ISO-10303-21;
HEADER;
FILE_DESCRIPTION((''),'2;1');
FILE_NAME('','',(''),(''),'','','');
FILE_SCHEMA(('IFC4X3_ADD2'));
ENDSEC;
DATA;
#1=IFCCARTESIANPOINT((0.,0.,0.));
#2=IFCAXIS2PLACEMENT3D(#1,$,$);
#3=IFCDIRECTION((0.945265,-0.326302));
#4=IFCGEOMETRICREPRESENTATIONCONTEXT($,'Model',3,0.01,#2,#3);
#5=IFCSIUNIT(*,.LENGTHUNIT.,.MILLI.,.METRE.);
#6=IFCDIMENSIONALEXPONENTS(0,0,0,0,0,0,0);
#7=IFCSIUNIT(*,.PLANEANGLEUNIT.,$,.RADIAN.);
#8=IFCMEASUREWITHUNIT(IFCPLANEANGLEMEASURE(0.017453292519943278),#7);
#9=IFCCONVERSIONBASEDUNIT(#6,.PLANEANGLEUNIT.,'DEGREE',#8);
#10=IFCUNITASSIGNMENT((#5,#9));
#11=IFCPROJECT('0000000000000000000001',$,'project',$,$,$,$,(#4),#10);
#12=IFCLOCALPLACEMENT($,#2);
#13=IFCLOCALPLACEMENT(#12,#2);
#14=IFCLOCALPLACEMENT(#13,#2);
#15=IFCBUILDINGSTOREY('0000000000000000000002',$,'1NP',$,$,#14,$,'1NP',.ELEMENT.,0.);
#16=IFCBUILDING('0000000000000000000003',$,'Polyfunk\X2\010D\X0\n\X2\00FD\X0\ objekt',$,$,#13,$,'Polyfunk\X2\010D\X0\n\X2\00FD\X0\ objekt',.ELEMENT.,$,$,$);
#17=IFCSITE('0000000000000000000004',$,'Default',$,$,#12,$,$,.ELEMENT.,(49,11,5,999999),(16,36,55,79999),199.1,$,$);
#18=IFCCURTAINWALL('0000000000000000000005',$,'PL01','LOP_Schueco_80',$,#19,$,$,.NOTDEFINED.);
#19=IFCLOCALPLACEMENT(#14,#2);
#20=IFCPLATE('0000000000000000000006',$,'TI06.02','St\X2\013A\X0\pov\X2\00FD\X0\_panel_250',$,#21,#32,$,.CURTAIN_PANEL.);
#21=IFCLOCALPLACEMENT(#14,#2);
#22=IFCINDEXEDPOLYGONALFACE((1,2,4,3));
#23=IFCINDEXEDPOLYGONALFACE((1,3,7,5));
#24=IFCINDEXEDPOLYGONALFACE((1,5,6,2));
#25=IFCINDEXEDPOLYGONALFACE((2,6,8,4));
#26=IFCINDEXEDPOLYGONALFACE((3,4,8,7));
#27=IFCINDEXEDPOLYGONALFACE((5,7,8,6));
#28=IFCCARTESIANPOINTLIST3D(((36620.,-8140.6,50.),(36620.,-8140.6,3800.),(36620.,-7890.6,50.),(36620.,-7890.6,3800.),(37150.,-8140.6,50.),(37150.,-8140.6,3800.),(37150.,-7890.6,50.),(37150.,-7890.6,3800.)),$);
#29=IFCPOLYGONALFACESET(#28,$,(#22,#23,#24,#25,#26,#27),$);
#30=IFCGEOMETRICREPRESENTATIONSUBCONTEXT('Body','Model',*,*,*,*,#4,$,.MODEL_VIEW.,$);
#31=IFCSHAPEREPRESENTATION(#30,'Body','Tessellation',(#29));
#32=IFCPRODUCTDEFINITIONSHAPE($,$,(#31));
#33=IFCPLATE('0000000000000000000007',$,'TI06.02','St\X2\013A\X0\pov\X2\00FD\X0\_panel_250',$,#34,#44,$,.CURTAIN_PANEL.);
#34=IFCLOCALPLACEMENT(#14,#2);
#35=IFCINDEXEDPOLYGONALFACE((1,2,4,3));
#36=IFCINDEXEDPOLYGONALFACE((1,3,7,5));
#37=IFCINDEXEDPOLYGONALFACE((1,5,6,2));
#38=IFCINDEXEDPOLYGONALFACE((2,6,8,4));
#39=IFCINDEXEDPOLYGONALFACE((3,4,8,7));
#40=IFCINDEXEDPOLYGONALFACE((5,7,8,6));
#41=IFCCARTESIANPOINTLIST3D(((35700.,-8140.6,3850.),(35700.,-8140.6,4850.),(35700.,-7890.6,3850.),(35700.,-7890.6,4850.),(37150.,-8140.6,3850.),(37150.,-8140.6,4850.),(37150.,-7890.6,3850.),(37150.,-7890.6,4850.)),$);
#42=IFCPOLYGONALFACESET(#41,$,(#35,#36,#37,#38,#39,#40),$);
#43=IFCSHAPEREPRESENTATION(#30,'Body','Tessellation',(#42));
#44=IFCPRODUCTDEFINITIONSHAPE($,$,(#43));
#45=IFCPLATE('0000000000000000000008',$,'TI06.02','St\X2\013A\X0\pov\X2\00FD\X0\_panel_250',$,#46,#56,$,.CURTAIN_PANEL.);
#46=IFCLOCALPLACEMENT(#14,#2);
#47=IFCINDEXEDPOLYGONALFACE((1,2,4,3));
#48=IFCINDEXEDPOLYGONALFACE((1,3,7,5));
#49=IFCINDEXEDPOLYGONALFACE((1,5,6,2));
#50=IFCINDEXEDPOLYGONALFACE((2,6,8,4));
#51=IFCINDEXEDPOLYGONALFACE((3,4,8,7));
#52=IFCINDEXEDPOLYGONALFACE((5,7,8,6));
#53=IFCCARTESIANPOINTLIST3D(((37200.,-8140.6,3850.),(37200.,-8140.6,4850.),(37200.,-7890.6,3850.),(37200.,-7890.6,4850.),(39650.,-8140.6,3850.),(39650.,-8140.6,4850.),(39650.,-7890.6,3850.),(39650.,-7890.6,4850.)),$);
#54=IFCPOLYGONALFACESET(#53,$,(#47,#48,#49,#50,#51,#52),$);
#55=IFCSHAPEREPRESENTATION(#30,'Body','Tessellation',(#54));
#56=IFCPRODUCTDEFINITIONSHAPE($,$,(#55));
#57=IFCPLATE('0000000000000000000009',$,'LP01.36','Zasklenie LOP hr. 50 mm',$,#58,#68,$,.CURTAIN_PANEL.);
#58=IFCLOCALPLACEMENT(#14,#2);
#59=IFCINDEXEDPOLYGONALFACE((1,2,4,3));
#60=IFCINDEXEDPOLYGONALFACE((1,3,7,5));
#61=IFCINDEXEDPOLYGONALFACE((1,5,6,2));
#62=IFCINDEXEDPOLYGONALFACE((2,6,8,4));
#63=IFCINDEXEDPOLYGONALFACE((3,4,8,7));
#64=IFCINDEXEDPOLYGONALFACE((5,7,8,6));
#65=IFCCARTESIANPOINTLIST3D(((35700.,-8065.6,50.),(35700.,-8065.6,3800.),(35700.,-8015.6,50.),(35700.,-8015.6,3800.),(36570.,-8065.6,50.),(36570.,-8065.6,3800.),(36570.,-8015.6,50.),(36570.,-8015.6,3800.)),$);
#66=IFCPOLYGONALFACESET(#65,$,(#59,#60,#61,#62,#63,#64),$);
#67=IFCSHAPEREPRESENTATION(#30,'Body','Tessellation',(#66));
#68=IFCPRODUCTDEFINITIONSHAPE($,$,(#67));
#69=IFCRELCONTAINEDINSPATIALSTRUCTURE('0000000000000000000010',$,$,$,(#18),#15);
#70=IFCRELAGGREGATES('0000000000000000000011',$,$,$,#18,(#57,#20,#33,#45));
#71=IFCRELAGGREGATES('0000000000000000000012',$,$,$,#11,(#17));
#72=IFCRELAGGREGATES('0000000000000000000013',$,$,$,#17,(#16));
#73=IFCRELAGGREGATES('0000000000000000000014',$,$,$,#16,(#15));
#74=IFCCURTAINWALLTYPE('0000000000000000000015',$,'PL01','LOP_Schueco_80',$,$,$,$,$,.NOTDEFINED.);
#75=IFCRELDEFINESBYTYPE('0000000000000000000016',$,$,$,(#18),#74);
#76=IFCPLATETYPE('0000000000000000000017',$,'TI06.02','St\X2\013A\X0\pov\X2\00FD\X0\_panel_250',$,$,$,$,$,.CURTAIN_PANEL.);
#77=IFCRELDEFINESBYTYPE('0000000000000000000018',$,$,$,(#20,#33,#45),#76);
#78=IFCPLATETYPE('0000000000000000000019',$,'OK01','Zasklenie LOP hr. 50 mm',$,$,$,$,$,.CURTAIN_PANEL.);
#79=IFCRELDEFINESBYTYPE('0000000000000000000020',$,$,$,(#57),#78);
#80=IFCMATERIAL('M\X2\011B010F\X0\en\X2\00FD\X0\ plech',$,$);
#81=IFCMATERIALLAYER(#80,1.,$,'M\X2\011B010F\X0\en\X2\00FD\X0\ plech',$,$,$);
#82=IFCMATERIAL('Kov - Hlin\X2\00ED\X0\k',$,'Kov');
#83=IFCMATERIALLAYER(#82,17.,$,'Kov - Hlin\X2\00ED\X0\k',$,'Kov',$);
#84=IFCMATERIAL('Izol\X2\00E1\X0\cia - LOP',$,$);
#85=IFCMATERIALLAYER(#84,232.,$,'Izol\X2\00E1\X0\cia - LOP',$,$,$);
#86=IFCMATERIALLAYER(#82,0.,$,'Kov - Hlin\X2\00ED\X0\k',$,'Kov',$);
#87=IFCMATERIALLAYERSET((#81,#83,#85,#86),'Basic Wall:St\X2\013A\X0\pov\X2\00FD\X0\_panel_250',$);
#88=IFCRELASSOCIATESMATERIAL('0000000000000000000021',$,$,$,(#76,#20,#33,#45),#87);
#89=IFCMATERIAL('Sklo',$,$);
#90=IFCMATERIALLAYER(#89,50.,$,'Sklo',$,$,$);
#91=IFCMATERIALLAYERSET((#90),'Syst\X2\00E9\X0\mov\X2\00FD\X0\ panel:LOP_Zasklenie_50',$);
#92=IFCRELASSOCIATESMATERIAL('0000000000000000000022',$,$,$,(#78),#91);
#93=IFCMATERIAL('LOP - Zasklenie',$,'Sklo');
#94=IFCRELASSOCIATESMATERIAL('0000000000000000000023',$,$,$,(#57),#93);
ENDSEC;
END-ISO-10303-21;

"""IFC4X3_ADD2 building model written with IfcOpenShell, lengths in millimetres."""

from ifc_helpers import new_model, entity, si_unit, converted_unit, direction, frame, frame_2d, origin, place, context, subcontext, project, spatial, rectangle, extrude, source, transform, mapped, material, layer, layer_set, layer_usage, type_object, type_shapes, element, aggregate, save


model = new_model("IFC4X3_ADD2")

# Units and contexts
model_context = context("Model", 3, precision=0.01, world=origin(), true_north=direction((0.945265, -0.326302)))
body_context = subcontext(model_context, "Body", "Model", "MODEL_VIEW")
ifc_project = project(units=[si_unit("LENGTHUNIT", "METRE", prefix="MILLI"), converted_unit("PLANEANGLEUNIT", "DEGREE", entity("IfcPlaneAngleMeasure", 0.017453292519943278), si_unit("PLANEANGLEUNIT", "RADIAN"), dimensions=[0, 0, 0, 0, 0, 0, 0])], contexts=[model_context])

# Site, building, storey
site_placement = place(None, origin())
site = spatial("IfcSite", under=ifc_project, at=site_placement, Name="Default", CompositionType="ELEMENT", RefLatitude=(49, 11, 5, 999999), RefLongitude=(16, 36, 55, 79999), RefElevation=199.1)
building_placement = place(site_placement, origin())
building = spatial("IfcBuilding", under=site, at=building_placement, Name="Polyfunkčný objekt", LongName="Polyfunkčný objekt", CompositionType="ELEMENT")
storey_placement = place(building_placement, origin())
storey = spatial("IfcBuildingStorey", under=building, at=storey_placement, Name="1NP", LongName="1NP", CompositionType="ELEMENT", Elevation=0.0)

# Curtain wall, plates
curtain_wall_type = type_object("IfcCurtainWallType", Name="PL01", Description="LOP_Schueco_80", PredefinedType="NOTDEFINED")
curtain_wall_placement = place(storey_placement, origin())
curtain_wall = element("IfcCurtainWall", 1, at=curtain_wall_placement, inside=storey, type_object=curtain_wall_type, Name="PL01", Description="LOP_Schueco_80", PredefinedType="NOTDEFINED")
ifc_material_1 = material(Name="Měďený plech")
ifc_layer_1 = layer(ifc_material_1, 1.0, Name="Měďený plech")
ifc_material_2 = material(Name="Kov - Hliník", Category="Kov")
ifc_layer_2 = layer(ifc_material_2, 17.0, Name="Kov - Hliník", Category="Kov")
ifc_material_3 = material(Name="Izolácia - LOP")
ifc_layer_3 = layer(ifc_material_3, 232.0, Name="Izolácia - LOP")
ifc_layer_4 = layer(ifc_material_2, 0.0, Name="Kov - Hliník", Category="Kov")
ifc_layer_set_1 = layer_set([ifc_layer_1, ifc_layer_2, ifc_layer_3, ifc_layer_4], Name="Basic Wall:Stĺpový_panel_250")
ifc_layer_usage_1 = layer_usage(ifc_layer_set_1, "AXIS2", "POSITIVE", -125.0)
plate_type_1 = type_object("IfcPlateType", Name="TI06.02", Description="Stĺpový_panel_250", PredefinedType="CURTAIN_PANEL", material=ifc_layer_set_1)
plate_1_placement = place(storey_placement, frame((36620.0, -8015.6, 50.0)))
plate_1 = element("IfcPlate", 2, at=plate_1_placement, type_object=plate_type_1, material=ifc_layer_usage_1, Name="TI06.02", Description="Stĺpový_panel_250", PredefinedType="CURTAIN_PANEL", context=body_context, shape_type="SweptSolid", body=[
    extrude(rectangle(XDim=250.0, YDim=530.0, at=frame_2d((0.0, 0.0), x_axis=(1.0, 0.0))), frame((265.0, 0.0, 0.0), z_axis=(0.0, 0.0, 1.0), x_axis=(0.0, 1.0, 0.0)), (0.0, 0.0, 1.0), 3750.0),
])
ifc_layer_usage_2 = layer_usage(ifc_layer_set_1, "AXIS2", "POSITIVE", -125.0)
plate_2_placement = place(storey_placement, frame((35700.0, -8015.6, 3850.0)))
plate_2 = element("IfcPlate", 3, at=plate_2_placement, type_object=plate_type_1, material=ifc_layer_usage_2, Name="TI06.02", Description="Stĺpový_panel_250", PredefinedType="CURTAIN_PANEL", context=body_context, shape_type="SweptSolid", body=[
    extrude(rectangle(XDim=250.0, YDim=1450.0, at=frame_2d((0.0, 0.0), x_axis=(1.0, 0.0))), frame((725.0, 0.0, 0.0), z_axis=(0.0, 0.0, 1.0), x_axis=(0.0, 1.0, 0.0)), (0.0, 0.0, 1.0), 1000.0),
])
ifc_layer_usage_3 = layer_usage(ifc_layer_set_1, "AXIS2", "POSITIVE", -125.0)
plate_3_placement = place(storey_placement, frame((37200.0, -8015.6, 3850.0)))
plate_3 = element("IfcPlate", 4, at=plate_3_placement, type_object=plate_type_1, material=ifc_layer_usage_3, Name="TI06.02", Description="Stĺpový_panel_250", PredefinedType="CURTAIN_PANEL", context=body_context, shape_type="SweptSolid", body=[
    extrude(rectangle(XDim=250.0, YDim=2450.0, at=frame_2d((0.0, 0.0), x_axis=(1.0, 0.0))), frame((1225.0, 0.0, 0.0), z_axis=(0.0, 0.0, 1.0), x_axis=(0.0, 1.0, 0.0)), (0.0, 0.0, 1.0), 1000.0),
])
ifc_material_4 = material(Name="LOP - Zasklenie", Category="Sklo")
ifc_material_5 = material(Name="Sklo")
ifc_layer_5 = layer(ifc_material_5, 50.0, Name="Sklo")
ifc_layer_set_2 = layer_set([ifc_layer_5], Name="Systémový panel:LOP_Zasklenie_50")
plate_type_2 = type_object("IfcPlateType", Name="OK01", Description="Zasklenie LOP hr. 50 mm", PredefinedType="CURTAIN_PANEL", material=ifc_layer_set_2)
shared_shape_1 = source(origin(), body_context, "Body", "SweptSolid", [
    extrude(rectangle(XDim=3750.0, YDim=870.0, at=frame_2d((-331.2, 0.0), x_axis=(1.0, 0.0))), frame((0.0, -50.0, 2206.2), z_axis=(0.0, 1.0, 0.0), x_axis=(0.0, 0.0, 1.0)), (0.0, 0.0, 1.0), 50.0),
])
type_shapes(plate_type_2, [shared_shape_1])
plate_4_placement = place(curtain_wall_placement, frame((36135.0, -8015.6, 50.0)))
plate_4 = element("IfcPlate", 5, at=plate_4_placement, type_object=plate_type_2, material=ifc_material_4, Name="LP01.36", Description="Zasklenie LOP hr. 50 mm", PredefinedType="CURTAIN_PANEL", context=body_context, shape_type="MappedRepresentation", body=[
    mapped(shared_shape_1, transform((0.0, 0.0, 0.0), scale=1.0)),
])
aggregate(curtain_wall, [plate_4, plate_1, plate_2, plate_3])

save(model, "model.ifc")
